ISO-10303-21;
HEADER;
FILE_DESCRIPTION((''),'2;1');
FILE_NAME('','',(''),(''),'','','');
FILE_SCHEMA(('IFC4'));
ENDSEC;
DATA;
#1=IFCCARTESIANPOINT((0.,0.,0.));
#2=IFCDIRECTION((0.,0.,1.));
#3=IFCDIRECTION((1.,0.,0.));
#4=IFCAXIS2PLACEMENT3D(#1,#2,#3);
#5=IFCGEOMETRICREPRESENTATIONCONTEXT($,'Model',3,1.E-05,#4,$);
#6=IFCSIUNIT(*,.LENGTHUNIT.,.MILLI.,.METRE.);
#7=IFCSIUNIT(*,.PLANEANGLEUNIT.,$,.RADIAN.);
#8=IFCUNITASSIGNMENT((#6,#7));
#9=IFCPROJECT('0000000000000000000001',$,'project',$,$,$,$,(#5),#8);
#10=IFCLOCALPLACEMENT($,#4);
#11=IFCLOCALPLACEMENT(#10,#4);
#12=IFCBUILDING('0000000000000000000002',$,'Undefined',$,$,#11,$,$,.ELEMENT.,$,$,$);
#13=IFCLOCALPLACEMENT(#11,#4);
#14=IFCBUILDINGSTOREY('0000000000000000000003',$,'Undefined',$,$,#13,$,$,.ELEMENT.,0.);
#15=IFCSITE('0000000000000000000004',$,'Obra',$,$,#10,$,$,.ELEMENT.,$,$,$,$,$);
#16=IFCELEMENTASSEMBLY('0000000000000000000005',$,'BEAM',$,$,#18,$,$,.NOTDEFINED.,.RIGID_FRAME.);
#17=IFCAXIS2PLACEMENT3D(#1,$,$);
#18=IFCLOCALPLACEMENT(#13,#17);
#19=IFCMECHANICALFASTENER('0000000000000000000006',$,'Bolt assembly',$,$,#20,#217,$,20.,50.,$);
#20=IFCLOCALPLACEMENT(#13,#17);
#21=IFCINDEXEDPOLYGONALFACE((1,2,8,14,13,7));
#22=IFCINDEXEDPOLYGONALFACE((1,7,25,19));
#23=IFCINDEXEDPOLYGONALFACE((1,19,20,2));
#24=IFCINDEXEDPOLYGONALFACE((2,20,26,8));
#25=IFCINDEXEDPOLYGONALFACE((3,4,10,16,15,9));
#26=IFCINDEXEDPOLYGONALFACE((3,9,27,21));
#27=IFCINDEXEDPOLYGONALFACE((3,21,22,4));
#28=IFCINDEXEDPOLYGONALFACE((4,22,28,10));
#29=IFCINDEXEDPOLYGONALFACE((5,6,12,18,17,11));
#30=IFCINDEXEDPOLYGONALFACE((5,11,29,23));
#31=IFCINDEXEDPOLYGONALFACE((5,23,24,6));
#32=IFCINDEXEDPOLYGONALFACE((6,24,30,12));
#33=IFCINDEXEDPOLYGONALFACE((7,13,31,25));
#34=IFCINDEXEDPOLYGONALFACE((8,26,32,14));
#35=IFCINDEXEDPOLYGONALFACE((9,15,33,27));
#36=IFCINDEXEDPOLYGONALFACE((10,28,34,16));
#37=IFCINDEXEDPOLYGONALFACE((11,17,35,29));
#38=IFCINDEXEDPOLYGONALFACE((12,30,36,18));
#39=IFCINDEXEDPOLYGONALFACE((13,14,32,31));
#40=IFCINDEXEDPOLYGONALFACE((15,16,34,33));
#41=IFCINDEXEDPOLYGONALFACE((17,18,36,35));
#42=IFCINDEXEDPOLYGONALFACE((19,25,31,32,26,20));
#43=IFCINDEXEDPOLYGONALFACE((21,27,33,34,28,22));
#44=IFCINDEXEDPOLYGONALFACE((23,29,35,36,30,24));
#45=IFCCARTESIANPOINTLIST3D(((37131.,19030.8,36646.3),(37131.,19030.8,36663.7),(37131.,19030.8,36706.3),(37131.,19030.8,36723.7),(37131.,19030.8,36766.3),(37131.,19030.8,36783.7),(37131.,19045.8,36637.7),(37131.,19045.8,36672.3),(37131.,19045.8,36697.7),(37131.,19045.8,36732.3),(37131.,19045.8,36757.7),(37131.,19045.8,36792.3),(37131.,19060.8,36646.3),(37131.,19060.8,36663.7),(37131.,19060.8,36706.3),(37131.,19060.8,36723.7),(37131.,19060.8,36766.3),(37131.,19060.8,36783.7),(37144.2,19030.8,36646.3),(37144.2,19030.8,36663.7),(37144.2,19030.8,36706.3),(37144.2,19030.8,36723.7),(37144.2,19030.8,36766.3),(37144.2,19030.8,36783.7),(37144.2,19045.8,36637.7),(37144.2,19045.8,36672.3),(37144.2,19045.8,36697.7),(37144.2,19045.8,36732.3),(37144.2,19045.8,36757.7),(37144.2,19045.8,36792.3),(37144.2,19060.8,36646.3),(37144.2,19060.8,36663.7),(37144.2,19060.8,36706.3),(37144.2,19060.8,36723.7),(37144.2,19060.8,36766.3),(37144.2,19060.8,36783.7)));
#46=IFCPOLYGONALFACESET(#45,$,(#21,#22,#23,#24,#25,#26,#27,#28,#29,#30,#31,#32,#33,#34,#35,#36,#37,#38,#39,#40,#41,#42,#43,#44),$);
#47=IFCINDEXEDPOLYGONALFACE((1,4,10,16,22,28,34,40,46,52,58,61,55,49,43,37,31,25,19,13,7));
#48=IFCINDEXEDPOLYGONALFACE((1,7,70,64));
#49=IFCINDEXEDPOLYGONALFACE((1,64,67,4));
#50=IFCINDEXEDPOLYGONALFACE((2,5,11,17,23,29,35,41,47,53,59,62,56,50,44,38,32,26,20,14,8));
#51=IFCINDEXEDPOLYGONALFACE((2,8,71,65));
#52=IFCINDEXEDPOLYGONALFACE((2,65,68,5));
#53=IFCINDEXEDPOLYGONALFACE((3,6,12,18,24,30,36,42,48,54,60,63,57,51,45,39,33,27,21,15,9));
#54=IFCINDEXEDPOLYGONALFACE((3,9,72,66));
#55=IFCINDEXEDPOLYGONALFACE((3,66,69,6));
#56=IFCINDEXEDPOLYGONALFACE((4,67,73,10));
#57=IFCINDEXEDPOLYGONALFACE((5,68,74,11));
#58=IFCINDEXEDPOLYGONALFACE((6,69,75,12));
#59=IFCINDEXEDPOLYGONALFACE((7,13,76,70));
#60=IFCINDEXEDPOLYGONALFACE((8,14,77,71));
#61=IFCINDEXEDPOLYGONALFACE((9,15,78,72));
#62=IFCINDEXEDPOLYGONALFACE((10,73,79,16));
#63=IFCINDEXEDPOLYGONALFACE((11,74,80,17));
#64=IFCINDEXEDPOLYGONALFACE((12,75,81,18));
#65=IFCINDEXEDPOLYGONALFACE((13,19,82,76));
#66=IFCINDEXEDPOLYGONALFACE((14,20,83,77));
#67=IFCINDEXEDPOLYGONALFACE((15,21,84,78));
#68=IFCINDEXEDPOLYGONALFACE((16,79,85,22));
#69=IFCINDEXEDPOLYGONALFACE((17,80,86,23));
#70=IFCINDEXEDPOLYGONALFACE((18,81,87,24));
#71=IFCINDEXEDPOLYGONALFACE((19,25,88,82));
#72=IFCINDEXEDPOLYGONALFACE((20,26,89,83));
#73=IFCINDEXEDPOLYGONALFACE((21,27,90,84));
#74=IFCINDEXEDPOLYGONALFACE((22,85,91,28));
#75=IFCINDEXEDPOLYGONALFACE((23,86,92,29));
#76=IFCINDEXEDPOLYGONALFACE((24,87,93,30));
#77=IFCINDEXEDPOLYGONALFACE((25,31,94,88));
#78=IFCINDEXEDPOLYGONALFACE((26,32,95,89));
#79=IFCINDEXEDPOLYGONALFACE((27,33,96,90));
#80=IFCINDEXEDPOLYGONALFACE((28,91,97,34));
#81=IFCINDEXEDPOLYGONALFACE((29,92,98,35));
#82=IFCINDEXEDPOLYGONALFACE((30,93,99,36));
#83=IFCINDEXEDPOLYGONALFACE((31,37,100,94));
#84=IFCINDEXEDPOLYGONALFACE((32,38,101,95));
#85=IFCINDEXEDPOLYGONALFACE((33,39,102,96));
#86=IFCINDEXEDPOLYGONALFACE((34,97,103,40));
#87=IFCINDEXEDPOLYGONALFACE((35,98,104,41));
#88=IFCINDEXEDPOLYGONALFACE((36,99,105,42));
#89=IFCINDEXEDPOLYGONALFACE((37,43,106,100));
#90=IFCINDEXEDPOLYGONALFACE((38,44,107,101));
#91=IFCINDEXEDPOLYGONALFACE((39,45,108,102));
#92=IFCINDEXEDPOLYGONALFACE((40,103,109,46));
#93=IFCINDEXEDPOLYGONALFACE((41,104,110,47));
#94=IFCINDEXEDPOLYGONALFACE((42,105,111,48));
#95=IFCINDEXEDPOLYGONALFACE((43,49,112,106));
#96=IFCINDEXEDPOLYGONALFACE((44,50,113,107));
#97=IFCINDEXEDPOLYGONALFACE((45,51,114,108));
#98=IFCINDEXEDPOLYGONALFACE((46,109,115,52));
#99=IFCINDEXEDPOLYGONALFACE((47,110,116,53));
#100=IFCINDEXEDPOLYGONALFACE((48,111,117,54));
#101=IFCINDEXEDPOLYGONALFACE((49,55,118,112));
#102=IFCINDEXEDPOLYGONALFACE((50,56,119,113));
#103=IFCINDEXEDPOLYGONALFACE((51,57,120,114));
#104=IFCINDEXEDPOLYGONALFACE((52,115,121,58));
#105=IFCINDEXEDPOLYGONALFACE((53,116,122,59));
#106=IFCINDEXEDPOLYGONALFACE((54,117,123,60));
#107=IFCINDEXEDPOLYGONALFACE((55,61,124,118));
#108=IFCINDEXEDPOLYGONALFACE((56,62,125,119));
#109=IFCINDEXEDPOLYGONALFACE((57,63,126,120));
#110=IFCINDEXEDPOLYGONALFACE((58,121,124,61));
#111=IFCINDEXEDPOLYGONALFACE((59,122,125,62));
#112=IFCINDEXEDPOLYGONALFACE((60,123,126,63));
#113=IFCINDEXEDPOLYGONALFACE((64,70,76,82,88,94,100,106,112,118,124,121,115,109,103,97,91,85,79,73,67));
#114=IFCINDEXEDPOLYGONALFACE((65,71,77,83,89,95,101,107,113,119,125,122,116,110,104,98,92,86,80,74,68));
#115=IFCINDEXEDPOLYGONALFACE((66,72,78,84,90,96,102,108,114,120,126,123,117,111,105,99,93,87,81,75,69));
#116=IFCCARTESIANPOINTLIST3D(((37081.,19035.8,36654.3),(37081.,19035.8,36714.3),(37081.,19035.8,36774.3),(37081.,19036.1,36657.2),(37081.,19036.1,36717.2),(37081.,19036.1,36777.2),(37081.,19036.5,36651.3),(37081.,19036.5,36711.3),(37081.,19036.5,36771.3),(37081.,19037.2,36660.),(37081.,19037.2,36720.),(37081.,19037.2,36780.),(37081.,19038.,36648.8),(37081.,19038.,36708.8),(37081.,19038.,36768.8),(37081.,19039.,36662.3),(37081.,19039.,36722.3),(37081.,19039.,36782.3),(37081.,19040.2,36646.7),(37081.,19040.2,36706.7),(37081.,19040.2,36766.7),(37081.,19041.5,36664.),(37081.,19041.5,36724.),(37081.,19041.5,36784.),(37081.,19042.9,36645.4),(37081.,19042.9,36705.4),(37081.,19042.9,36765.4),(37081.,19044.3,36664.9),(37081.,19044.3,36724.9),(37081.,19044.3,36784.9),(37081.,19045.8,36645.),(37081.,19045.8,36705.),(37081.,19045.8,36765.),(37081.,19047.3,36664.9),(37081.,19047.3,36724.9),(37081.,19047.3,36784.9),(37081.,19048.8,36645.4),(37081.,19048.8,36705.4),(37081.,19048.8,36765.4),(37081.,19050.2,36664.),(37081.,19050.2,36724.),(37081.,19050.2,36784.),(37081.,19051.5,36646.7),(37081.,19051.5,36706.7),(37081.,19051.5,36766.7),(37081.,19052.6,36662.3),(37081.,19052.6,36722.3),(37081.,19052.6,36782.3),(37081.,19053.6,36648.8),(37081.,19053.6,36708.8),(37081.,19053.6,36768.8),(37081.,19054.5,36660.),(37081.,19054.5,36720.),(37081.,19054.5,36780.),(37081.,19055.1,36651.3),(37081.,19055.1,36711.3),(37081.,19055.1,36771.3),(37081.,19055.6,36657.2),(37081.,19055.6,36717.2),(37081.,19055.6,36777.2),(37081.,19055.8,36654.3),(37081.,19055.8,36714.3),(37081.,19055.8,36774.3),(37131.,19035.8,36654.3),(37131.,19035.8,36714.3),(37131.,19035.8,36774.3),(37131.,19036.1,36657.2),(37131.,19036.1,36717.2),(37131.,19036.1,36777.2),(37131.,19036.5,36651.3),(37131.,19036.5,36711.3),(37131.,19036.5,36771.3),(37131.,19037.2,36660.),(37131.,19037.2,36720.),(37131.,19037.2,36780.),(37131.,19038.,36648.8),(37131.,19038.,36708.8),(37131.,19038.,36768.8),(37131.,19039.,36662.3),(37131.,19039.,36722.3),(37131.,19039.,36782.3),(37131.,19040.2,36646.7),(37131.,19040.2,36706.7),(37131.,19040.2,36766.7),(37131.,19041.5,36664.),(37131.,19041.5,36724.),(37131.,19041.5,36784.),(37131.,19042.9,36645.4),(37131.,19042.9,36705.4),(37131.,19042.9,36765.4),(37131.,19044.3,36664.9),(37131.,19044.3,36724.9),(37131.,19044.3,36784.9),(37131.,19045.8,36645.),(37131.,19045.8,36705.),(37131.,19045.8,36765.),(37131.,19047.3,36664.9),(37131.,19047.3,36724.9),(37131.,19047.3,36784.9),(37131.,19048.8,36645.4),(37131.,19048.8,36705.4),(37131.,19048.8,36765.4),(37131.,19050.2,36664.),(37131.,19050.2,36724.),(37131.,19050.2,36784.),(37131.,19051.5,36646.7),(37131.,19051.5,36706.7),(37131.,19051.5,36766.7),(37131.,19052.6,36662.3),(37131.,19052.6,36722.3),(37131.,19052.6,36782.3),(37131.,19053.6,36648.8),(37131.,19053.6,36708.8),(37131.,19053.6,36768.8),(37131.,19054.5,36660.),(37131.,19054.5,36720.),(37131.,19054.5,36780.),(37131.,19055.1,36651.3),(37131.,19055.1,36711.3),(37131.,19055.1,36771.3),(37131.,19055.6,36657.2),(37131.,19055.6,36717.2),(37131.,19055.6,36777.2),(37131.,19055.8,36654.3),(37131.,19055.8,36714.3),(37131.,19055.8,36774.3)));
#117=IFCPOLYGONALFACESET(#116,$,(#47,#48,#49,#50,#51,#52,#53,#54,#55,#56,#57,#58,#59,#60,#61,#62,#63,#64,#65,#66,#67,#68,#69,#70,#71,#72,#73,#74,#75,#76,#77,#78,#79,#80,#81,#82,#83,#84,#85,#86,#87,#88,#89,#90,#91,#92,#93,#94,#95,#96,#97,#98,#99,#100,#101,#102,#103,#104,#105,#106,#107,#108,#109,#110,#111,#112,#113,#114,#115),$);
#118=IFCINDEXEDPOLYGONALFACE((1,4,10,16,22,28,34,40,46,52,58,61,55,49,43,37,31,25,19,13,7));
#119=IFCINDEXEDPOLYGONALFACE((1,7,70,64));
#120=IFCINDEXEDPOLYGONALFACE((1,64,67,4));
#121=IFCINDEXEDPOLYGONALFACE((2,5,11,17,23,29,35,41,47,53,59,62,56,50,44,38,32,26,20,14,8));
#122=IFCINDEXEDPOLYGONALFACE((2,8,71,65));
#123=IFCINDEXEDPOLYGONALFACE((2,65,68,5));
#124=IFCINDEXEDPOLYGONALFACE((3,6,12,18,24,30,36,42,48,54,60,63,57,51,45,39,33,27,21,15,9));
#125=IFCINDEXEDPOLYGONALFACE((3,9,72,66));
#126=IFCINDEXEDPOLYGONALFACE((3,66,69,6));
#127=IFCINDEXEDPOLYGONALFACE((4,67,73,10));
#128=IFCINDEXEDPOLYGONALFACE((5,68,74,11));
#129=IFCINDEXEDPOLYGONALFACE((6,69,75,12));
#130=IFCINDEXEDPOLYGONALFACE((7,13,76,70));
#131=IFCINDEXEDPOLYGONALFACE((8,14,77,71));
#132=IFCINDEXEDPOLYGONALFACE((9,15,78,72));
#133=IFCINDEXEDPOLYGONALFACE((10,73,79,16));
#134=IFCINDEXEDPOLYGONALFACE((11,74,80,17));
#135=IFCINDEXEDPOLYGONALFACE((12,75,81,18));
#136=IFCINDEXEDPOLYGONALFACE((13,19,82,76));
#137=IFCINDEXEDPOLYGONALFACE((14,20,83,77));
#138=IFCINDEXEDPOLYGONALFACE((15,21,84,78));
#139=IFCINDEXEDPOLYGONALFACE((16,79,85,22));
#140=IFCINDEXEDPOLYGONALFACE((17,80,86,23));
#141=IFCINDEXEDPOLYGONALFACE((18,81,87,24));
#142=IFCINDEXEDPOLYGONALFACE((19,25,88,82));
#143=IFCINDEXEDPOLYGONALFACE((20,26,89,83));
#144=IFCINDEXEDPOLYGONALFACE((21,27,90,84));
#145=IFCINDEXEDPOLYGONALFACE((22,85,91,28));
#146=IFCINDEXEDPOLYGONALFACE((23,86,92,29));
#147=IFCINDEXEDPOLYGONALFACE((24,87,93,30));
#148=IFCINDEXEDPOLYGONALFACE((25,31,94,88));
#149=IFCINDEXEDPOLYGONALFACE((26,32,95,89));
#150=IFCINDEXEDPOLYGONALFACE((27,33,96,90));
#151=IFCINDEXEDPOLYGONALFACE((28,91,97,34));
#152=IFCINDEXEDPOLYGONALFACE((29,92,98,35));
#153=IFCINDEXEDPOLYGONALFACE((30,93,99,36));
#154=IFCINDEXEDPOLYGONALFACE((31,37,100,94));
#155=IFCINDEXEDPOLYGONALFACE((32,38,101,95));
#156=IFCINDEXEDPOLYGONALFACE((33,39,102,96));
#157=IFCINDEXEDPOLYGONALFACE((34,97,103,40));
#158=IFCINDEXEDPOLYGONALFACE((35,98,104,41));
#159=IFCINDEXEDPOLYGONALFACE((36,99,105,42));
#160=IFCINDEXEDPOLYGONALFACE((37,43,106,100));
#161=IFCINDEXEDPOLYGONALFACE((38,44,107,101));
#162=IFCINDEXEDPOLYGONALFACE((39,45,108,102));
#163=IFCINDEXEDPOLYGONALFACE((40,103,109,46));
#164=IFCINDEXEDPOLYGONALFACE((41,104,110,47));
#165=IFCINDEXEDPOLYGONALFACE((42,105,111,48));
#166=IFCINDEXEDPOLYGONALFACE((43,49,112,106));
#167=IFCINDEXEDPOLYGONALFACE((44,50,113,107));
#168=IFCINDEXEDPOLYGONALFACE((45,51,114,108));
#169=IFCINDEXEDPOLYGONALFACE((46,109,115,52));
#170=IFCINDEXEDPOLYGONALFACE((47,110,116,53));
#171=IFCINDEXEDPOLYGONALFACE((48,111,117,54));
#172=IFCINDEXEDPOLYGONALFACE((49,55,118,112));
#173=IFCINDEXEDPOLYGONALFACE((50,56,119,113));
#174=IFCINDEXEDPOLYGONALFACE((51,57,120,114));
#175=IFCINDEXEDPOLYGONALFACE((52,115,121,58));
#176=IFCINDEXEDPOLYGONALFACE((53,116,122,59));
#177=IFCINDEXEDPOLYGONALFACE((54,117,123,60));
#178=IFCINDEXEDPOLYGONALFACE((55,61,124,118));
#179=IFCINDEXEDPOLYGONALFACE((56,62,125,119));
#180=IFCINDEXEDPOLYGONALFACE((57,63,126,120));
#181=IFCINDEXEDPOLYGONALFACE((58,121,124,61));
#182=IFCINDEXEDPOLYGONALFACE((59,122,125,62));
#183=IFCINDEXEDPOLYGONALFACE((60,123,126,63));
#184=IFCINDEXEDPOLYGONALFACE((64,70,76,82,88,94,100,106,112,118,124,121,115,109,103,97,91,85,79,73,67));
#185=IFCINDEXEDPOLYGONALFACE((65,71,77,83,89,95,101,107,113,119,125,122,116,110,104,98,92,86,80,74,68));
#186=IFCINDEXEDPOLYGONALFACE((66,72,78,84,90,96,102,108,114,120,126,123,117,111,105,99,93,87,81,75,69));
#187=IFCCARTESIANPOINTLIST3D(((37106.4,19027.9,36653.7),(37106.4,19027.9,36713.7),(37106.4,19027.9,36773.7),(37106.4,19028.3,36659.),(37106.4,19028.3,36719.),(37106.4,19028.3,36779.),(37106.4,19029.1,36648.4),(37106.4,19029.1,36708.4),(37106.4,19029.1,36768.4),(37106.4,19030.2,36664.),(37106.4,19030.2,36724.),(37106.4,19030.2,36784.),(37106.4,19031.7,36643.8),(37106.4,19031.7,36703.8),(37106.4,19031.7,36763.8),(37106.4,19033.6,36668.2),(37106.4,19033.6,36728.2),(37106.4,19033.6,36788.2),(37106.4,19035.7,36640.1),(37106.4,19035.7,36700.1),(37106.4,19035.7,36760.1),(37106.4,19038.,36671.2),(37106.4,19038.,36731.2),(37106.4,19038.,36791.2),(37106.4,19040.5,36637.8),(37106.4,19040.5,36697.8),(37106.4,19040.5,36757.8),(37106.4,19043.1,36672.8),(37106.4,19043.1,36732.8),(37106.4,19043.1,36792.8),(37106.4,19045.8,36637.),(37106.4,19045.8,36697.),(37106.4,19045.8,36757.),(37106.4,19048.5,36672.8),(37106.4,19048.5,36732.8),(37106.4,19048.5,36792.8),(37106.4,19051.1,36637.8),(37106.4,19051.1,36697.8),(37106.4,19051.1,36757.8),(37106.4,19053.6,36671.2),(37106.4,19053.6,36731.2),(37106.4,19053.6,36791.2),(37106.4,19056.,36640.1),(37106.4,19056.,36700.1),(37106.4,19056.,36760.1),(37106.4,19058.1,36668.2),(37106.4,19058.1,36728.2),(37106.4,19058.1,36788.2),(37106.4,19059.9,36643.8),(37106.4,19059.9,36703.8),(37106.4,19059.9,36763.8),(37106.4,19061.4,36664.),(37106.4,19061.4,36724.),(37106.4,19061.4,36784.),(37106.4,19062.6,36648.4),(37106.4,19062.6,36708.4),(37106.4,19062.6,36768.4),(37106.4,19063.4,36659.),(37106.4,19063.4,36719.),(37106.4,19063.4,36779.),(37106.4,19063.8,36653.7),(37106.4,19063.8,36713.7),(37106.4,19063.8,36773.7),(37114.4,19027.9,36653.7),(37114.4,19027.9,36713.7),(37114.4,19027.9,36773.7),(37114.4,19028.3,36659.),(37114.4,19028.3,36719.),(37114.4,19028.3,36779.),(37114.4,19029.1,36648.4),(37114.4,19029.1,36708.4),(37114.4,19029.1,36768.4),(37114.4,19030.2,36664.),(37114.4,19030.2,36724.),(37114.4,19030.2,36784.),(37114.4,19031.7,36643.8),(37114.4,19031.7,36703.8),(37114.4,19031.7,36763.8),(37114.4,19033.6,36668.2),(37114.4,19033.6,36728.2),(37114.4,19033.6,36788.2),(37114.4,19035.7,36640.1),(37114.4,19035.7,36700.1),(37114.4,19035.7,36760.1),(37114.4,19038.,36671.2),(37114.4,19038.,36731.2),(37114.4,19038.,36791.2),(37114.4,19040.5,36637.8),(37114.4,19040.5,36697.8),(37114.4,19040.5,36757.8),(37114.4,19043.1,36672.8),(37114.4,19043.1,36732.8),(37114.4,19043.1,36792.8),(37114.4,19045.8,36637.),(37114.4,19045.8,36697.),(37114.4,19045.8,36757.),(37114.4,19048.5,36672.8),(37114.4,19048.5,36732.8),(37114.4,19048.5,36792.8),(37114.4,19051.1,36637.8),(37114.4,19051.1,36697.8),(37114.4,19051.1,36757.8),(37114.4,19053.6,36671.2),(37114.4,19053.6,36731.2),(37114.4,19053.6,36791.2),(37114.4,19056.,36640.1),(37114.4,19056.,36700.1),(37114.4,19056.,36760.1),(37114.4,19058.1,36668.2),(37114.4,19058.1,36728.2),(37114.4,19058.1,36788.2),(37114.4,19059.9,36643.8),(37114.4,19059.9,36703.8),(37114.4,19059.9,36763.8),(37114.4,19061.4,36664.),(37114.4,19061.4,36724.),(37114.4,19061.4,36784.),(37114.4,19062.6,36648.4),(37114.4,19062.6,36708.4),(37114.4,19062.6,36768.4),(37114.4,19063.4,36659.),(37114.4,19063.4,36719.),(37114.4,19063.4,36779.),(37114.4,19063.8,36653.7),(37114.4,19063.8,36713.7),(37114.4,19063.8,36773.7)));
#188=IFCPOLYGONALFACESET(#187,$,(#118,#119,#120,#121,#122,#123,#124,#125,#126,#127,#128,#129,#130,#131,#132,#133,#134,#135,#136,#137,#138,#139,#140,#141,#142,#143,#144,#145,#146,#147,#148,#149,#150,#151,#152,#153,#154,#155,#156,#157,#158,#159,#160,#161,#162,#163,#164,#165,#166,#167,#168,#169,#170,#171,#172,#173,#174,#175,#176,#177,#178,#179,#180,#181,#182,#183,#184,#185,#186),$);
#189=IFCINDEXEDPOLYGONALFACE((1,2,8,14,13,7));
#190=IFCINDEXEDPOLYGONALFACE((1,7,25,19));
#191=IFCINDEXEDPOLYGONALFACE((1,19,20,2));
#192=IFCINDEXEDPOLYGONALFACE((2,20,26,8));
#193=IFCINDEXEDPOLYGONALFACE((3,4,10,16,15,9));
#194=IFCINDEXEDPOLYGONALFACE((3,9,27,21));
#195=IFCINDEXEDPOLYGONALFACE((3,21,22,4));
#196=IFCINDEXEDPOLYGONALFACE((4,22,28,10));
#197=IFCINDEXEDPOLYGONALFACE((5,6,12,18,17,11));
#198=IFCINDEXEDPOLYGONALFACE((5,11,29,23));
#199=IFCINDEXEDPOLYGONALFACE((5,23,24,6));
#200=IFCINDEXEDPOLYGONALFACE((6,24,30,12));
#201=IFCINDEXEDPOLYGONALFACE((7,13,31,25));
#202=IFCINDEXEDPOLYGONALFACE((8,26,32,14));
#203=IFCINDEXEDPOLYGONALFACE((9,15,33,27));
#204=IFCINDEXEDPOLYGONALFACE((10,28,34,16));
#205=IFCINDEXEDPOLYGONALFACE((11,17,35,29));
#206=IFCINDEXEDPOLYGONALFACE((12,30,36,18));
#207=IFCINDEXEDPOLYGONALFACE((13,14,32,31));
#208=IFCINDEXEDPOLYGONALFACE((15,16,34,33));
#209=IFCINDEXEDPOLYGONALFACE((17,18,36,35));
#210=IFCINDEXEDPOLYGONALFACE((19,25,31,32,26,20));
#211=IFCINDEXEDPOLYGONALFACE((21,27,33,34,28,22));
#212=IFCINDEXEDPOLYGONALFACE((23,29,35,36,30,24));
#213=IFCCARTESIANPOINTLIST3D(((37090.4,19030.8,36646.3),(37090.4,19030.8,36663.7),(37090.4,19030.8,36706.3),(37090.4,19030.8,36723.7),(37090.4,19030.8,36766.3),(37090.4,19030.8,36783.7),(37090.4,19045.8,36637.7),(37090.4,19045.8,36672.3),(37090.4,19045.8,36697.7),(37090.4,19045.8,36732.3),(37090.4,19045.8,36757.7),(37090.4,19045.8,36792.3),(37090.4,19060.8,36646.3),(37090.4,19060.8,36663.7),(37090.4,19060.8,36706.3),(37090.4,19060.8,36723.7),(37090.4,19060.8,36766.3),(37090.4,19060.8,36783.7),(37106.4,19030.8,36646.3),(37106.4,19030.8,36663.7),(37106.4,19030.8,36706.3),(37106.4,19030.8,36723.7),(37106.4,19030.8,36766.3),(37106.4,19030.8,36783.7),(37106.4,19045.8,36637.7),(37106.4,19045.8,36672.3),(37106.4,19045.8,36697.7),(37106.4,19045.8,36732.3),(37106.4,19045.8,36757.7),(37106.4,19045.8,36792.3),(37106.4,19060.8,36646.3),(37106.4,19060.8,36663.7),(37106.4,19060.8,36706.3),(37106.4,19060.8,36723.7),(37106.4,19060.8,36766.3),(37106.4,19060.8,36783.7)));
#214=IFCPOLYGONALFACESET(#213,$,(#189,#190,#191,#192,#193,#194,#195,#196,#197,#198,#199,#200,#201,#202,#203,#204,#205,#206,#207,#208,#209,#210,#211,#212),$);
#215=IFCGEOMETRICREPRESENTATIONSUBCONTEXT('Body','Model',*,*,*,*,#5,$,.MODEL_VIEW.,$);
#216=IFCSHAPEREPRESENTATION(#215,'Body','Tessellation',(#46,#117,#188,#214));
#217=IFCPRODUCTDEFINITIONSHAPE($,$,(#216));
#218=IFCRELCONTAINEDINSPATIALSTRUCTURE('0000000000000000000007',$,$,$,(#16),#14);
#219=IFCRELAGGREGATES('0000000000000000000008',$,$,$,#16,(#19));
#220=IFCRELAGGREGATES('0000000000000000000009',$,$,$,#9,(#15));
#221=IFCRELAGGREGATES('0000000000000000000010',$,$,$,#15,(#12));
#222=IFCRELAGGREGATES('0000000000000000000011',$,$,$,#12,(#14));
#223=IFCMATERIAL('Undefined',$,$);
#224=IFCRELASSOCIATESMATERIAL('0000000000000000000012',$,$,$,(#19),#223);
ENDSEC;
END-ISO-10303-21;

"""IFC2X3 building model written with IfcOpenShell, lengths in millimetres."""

from ifc_helpers import new_model, si_unit, frame, origin_with_axes, origin_2d_with_axis, place, context, subcontext, project, spatial, polyline, circle, outline, extrude, source, transform, mapped, material, element, aggregate, save


model = new_model("IFC2X3")

# Units and contexts
model_context = context("Model", 3, precision=1e-05, world=origin_with_axes())
body_context = subcontext(model_context, "Body", "Model", "MODEL_VIEW")
ifc_project = project(units=[si_unit("LENGTHUNIT", "METRE", prefix="MILLI"), si_unit("PLANEANGLEUNIT", "RADIAN")], contexts=[model_context])

# Site, building, storey
site_placement = place(None, origin_with_axes())
site = spatial("IfcSite", under=ifc_project, at=site_placement, Name="Obra", CompositionType="ELEMENT")
building_placement = place(site_placement, origin_with_axes())
building = spatial("IfcBuilding", under=site, at=building_placement, Name="Undefined", CompositionType="ELEMENT")
storey_placement = place(building_placement, origin_with_axes())
storey = spatial("IfcBuildingStorey", under=building, at=storey_placement, Name="Undefined", CompositionType="ELEMENT", Elevation=0.0)

# Element assembly
assembly_1_placement = place(storey_placement, origin_with_axes())
assembly_1 = element("IfcElementAssembly", 1, at=assembly_1_placement, inside=storey, Name="BEAM", AssemblyPlace="NOTDEFINED", PredefinedType="RIGID_FRAME")

# Mechanical fastener
ifc_material_1 = material(Name="Undefined")
shared_shape_1 = source(origin_with_axes(), body_context, "Body", "SweptSolid", [
    extrude(outline(polyline([(17.3, 0.0), (8.7, 15.0), (-8.7, 15.0), (-17.3, 0.0), (-8.7, -15.0), (8.7, -15.0), (17.3, 0.0)])), frame((0.0, -26.5, 0.0), z_axis=(0.0, 1.0, 0.0), x_axis=(1.0, 0.0, 0.0)), (0.0, 0.0, 1.0), 13.2),
    extrude(circle(Radius=10.0, at=origin_2d_with_axis()), frame((0.0, -13.3, 0.0), z_axis=(0.0, 1.0, 0.0), x_axis=(1.0, 0.0, 0.0)), (0.0, 0.0, 1.0), 50.0),
    extrude(circle(Radius=18.0, at=origin_2d_with_axis()), frame((0.0, 3.3, 0.0), z_axis=(0.0, 1.0, 0.0), x_axis=(1.0, 0.0, 0.0)), (0.0, 0.0, 1.0), 8.0),
    extrude(outline(polyline([(17.3, 0.0), (8.7, 15.0), (-8.7, 15.0), (-17.3, 0.0), (-8.7, -15.0), (8.7, -15.0), (17.3, 0.0)])), frame((0.0, 11.3, 0.0), z_axis=(0.0, 1.0, 0.0), x_axis=(1.0, 0.0, 0.0)), (0.0, 0.0, 1.0), 16.0),
])
mechanical_fastener_1_placement = place(assembly_1_placement, frame((37117.7, 18995.8, 36815.0), z_axis=(0.0, 1.0, 0.0), x_axis=(0.0, 0.0, -1.0)))
mechanical_fastener_1 = element("IfcMechanicalFastener", 2, at=mechanical_fastener_1_placement, material=ifc_material_1, Name="Bolt assembly", NominalDiameter=20.0, NominalLength=50.0, context=body_context, shape_type="MappedRepresentation", body=[
    mapped(shared_shape_1, transform((40.0, 0.0, 50.0))),
    mapped(shared_shape_1, transform((100.0, 0.0, 50.0))),
    mapped(shared_shape_1, transform((160.0, 0.0, 50.0))),
])
aggregate(assembly_1, [mechanical_fastener_1])

save(model, "model.ifc")
